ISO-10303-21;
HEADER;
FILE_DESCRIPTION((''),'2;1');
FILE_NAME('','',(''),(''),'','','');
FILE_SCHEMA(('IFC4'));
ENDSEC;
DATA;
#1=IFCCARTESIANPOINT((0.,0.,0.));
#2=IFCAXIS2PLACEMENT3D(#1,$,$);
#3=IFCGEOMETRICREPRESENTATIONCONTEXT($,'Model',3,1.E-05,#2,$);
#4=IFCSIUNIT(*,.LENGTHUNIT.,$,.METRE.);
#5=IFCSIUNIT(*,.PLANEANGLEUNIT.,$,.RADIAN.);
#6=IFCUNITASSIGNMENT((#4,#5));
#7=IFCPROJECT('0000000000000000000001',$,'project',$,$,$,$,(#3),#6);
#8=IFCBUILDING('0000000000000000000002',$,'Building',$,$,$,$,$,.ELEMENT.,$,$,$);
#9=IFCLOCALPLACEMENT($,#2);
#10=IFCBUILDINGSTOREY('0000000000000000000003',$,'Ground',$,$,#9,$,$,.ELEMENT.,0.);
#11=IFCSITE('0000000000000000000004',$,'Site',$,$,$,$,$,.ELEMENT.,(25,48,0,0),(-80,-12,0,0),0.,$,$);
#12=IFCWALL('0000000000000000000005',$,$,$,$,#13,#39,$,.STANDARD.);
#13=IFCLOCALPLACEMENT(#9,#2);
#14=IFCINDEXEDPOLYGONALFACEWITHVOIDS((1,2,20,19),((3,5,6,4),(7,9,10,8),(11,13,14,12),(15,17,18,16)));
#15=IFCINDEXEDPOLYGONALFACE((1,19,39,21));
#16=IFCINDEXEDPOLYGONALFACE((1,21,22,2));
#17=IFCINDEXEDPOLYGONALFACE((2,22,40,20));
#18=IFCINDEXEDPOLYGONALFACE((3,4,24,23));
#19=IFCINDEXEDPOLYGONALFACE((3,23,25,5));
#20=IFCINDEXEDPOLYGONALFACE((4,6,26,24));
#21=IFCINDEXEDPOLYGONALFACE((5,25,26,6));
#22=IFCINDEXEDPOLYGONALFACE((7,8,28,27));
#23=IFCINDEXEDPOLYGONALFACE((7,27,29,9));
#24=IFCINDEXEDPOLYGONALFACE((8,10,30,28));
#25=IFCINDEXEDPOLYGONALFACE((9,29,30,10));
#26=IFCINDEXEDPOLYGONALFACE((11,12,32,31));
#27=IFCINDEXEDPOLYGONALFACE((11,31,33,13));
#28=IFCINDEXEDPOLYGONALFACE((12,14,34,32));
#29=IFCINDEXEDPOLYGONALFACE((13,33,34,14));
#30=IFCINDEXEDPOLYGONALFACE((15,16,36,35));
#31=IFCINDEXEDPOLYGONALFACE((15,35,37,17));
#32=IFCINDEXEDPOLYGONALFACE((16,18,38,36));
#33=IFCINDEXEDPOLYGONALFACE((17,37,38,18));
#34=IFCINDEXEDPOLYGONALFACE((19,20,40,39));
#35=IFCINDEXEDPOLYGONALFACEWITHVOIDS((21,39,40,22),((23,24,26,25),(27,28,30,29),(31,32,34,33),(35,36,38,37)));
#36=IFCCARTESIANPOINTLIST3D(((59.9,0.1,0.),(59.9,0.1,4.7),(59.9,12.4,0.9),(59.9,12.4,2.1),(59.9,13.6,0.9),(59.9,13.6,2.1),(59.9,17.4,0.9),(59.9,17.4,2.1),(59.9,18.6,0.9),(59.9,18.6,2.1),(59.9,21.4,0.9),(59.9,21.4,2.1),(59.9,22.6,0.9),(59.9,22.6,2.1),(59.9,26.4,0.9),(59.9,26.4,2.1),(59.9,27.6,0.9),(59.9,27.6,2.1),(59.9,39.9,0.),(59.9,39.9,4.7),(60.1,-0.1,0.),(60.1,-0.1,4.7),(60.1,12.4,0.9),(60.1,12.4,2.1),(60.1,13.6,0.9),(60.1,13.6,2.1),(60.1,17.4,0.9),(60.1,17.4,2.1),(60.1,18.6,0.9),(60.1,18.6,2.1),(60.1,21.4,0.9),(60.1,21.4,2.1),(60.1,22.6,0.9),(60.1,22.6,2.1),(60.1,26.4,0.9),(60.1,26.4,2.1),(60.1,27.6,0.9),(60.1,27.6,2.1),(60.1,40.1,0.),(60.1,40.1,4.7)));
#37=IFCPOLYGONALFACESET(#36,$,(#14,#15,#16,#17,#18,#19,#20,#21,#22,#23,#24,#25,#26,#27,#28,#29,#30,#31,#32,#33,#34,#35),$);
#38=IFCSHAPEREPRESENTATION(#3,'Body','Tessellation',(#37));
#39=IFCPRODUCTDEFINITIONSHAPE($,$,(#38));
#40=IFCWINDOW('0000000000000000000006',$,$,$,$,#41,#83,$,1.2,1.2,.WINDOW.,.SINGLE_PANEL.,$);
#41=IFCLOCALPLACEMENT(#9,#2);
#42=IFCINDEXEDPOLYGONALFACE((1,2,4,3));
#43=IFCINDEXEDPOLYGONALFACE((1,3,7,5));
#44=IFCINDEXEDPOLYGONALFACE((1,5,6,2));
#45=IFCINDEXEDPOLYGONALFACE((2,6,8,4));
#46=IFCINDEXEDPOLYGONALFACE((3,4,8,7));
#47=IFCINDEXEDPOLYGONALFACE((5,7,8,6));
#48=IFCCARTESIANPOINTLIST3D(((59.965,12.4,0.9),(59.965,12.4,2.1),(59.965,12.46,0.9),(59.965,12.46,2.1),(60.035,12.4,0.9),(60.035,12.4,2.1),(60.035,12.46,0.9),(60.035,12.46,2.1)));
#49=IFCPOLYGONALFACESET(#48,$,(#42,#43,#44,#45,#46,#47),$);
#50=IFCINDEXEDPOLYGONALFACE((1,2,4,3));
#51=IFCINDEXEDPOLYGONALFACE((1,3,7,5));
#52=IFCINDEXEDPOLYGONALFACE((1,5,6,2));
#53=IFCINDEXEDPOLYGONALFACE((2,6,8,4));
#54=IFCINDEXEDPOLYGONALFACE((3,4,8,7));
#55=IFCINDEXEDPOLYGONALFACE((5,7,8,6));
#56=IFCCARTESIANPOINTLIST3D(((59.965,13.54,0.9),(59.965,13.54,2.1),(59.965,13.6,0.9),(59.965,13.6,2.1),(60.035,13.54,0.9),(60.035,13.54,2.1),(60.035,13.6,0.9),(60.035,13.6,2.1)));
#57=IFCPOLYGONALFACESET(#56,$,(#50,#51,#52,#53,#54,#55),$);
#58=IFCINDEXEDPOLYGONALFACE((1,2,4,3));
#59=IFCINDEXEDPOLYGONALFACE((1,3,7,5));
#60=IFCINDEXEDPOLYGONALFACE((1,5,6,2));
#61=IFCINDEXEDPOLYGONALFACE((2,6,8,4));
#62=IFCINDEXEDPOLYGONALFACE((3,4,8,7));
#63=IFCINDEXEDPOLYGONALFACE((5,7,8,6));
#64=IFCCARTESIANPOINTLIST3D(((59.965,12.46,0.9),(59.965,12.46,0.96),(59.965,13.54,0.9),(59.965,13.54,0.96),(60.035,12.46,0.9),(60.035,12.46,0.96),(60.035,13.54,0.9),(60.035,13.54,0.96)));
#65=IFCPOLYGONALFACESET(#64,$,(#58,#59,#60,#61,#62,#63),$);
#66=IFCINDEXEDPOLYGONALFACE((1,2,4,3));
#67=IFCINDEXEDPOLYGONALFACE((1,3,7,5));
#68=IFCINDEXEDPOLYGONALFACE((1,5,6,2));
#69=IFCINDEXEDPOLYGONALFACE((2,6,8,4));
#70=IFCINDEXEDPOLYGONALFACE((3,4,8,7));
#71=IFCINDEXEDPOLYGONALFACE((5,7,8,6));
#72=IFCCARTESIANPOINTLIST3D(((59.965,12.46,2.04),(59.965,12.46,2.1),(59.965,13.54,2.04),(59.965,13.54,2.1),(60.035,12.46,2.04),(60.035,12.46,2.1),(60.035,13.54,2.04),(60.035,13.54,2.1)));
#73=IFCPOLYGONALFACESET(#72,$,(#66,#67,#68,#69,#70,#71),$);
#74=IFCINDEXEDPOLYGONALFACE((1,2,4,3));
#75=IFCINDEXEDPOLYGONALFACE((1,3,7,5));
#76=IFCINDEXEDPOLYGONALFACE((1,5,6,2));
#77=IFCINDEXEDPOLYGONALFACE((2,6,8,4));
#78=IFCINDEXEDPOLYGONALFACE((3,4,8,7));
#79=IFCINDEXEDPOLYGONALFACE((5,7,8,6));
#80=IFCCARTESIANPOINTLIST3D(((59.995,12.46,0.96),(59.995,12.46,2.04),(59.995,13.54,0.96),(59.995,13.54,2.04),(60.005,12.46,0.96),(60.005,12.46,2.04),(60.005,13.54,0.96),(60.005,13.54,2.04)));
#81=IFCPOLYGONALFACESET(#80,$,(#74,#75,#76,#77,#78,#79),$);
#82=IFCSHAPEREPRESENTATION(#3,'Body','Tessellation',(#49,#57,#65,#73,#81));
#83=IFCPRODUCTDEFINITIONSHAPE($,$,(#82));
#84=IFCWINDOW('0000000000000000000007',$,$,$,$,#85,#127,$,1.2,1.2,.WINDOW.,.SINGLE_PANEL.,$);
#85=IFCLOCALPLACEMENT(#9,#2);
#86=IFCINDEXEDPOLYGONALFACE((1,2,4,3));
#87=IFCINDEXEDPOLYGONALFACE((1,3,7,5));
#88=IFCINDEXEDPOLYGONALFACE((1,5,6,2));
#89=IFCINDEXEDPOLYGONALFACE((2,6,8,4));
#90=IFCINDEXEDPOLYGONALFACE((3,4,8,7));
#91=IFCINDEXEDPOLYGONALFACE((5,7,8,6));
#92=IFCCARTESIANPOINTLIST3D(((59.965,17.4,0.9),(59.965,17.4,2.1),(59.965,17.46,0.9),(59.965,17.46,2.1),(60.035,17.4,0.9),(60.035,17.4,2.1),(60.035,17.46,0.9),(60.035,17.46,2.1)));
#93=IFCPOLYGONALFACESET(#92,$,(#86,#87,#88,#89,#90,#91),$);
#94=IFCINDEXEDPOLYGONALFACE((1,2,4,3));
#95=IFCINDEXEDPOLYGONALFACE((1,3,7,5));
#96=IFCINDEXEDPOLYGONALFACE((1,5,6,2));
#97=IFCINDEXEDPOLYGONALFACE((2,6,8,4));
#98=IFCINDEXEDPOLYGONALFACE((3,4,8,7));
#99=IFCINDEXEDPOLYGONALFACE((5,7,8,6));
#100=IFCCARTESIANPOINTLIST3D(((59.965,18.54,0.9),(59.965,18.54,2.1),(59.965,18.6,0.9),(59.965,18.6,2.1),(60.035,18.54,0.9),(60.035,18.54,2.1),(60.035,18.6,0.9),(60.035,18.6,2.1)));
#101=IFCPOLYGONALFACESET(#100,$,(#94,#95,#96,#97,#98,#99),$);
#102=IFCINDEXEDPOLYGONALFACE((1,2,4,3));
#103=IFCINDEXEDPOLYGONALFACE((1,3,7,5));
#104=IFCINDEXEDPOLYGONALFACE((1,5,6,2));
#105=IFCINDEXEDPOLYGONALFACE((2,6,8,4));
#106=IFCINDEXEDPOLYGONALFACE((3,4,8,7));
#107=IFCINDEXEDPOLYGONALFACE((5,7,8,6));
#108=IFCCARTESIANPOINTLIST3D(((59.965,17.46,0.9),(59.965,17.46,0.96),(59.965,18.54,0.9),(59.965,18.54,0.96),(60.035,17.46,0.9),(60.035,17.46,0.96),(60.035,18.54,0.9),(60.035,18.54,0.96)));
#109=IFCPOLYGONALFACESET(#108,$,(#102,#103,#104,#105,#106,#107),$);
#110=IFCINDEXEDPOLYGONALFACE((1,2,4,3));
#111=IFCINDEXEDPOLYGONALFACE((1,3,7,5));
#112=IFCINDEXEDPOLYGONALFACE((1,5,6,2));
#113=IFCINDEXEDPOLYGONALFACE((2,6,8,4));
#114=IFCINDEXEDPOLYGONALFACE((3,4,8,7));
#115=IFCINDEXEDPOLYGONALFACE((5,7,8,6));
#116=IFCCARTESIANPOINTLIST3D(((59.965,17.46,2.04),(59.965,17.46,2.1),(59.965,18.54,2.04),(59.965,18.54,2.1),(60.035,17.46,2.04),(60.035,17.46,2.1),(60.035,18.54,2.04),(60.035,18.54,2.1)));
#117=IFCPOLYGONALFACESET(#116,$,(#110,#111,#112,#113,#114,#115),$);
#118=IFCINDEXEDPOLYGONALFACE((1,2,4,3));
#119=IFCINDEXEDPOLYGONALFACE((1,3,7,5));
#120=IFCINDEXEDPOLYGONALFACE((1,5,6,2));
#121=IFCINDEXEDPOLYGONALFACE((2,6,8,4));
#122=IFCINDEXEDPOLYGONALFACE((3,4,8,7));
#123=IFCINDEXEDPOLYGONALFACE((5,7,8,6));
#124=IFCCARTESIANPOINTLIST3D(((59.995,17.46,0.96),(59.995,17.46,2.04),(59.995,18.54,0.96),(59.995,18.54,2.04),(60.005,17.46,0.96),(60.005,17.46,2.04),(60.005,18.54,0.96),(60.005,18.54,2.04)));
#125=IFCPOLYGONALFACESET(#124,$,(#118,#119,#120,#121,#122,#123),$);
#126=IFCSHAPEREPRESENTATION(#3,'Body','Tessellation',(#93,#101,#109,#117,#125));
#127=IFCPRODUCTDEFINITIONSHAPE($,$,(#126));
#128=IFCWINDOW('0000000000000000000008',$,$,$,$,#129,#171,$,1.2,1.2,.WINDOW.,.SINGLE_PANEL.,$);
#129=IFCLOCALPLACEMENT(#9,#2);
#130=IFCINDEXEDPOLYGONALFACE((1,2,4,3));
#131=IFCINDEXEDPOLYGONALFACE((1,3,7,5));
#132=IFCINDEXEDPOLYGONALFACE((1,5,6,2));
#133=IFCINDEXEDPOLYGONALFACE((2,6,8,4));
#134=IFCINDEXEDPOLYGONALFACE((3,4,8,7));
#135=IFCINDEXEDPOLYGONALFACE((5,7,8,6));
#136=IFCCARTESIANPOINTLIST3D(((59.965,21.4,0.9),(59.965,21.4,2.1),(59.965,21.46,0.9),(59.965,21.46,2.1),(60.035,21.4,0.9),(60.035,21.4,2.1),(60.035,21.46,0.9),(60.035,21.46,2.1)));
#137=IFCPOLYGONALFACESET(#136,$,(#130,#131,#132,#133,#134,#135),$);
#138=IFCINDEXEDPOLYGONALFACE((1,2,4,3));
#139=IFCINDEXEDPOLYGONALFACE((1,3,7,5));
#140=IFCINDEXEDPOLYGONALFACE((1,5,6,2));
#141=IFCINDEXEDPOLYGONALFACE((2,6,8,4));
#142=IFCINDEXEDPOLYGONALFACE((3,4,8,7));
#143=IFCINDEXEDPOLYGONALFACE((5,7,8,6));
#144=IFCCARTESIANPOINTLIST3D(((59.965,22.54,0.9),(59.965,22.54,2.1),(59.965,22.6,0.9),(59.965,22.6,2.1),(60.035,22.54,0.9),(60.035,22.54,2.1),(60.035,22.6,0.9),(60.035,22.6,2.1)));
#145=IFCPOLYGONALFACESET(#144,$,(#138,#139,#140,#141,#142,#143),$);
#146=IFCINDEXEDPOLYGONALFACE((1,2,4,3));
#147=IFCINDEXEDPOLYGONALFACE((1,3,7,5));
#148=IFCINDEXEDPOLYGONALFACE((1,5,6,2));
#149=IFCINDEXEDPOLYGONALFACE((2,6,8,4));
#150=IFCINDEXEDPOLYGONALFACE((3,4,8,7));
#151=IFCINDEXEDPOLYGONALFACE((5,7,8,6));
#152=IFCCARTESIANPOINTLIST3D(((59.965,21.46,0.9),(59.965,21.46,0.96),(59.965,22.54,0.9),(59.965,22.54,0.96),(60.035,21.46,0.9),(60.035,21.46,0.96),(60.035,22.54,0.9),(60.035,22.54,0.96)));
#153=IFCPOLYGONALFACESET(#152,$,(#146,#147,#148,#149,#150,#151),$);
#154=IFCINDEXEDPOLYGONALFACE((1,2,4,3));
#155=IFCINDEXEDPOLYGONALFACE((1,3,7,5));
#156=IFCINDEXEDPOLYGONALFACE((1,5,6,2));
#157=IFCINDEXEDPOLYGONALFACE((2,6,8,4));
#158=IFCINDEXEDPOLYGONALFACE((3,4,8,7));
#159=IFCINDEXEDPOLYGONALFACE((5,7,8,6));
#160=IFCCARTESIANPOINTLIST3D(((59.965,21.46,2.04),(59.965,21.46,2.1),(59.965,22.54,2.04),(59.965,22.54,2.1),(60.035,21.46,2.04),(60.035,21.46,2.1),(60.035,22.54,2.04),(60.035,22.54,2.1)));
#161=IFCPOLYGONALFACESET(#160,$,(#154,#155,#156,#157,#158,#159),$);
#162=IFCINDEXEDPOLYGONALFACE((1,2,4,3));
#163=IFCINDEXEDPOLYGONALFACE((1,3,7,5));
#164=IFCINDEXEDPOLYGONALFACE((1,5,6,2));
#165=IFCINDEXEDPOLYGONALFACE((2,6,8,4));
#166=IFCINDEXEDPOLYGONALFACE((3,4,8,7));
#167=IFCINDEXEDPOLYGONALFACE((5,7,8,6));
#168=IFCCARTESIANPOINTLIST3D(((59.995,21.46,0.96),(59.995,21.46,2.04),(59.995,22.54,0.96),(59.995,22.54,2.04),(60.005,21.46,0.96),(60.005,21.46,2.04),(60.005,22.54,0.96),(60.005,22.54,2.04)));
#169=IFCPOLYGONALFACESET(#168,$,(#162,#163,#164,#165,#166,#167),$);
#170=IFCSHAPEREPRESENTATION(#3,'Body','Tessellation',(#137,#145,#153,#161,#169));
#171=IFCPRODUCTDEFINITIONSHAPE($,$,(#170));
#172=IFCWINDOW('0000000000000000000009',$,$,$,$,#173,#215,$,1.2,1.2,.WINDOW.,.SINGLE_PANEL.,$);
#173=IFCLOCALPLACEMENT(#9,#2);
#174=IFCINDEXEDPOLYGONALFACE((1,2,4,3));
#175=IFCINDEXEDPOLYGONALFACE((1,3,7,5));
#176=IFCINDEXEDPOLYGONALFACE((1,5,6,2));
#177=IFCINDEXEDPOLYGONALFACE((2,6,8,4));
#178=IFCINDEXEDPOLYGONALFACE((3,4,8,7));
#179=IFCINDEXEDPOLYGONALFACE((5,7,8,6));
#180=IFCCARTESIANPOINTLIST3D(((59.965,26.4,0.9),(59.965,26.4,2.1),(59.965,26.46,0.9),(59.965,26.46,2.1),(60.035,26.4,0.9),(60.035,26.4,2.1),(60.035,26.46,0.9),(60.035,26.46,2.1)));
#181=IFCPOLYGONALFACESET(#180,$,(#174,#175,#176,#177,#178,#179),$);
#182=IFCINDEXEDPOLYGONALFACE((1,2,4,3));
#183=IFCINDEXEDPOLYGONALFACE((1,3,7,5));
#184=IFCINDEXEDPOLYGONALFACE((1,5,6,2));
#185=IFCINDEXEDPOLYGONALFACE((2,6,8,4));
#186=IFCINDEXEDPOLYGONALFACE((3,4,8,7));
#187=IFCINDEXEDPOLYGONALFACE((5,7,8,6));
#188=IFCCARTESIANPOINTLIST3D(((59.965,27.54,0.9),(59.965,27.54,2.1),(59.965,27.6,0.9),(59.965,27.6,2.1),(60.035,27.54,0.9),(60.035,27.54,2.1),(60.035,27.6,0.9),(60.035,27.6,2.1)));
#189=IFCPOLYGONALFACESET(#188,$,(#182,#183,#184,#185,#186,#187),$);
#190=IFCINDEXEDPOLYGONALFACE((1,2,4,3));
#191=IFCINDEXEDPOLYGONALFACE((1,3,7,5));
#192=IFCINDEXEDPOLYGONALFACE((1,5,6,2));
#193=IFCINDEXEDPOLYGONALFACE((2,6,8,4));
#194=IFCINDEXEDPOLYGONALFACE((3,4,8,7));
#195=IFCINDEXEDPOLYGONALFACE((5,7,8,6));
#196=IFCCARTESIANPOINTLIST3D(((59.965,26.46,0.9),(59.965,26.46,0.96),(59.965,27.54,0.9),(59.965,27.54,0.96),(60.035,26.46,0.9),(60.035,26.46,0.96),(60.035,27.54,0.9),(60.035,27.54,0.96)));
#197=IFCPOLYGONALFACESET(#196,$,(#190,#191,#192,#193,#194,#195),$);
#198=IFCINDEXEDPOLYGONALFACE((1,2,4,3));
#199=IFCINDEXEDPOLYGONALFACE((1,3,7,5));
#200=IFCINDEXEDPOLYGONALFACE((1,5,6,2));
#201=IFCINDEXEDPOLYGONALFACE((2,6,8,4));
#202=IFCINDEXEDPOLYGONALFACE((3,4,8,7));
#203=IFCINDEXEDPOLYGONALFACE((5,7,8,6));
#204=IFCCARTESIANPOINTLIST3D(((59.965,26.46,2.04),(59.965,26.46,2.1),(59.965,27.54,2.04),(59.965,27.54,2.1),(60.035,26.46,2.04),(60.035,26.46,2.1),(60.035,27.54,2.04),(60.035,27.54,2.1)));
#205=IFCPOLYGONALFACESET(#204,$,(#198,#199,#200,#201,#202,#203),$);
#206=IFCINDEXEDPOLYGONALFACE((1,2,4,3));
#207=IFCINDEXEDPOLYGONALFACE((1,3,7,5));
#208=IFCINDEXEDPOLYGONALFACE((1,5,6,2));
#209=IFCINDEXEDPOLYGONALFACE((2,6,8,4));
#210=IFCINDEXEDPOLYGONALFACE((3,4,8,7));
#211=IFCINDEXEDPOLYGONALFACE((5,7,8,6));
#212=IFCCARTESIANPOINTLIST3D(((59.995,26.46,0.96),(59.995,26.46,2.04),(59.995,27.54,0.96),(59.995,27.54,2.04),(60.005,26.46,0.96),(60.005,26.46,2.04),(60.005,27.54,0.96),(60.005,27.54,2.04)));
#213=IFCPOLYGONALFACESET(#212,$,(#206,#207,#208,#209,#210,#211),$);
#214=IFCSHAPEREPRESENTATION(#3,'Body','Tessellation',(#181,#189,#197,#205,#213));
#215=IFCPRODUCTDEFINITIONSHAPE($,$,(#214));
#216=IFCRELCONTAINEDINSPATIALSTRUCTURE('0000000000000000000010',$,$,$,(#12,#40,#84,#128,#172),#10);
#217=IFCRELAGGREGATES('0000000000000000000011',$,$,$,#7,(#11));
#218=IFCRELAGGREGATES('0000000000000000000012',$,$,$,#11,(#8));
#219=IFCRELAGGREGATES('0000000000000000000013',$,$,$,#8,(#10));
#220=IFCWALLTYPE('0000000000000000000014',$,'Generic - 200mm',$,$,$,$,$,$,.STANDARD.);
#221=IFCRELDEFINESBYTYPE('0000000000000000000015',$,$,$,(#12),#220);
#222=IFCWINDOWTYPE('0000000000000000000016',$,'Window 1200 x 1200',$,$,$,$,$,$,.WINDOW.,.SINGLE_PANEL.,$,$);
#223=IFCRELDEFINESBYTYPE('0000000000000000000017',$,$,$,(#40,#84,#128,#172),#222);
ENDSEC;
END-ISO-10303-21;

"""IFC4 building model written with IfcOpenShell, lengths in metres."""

from ifc_helpers import new_model, si_unit, frame, frame_2d, origin, origin_with_axes, origin_2d, place, context, project, spatial, polyline, rectangle, outline, extrude, type_object, element, fill, save


model = new_model("IFC4")

# Units and contexts
model_context = context("Model", 3, precision=1e-05, world=origin())
ifc_project = project(units=[si_unit("LENGTHUNIT", "METRE"), si_unit("PLANEANGLEUNIT", "RADIAN")], contexts=[model_context])

# Site, building, storey
site = spatial("IfcSite", under=ifc_project, Name="Site", CompositionType="ELEMENT", RefLatitude=(25, 48, 0, 0), RefLongitude=(-80, -12, 0, 0), RefElevation=0.0)
building = spatial("IfcBuilding", under=site, Name="Building", CompositionType="ELEMENT")
storey_placement = place(None, origin())
storey = spatial("IfcBuildingStorey", under=building, at=storey_placement, Name="Ground", CompositionType="ELEMENT", Elevation=0.0)

# Wall, openings, windows
wall_type_1 = type_object("IfcWallType", Name="Generic - 200mm", PredefinedType="STANDARD")
wall_1_placement = place(None, frame((60.0, 0.0, 0.0), z_axis=(0.0, 0.0, 1.0), x_axis=(0.0, 1.0, 0.0)))
wall_1 = element("IfcWall", 1, at=wall_1_placement, inside=storey, type_object=wall_type_1, PredefinedType="STANDARD", context=model_context, shape_type="SweptSolid", body=[
    extrude(outline(polyline([(-0.1, -0.1), (40.1, -0.1), (39.9, 0.1), (0.1, 0.1), (-0.1, -0.1)])), origin(), (0.0, 0.0, 1.0), 4.7),
])
opening_1_placement = place(wall_1_placement, frame((13.0, 0.0, 0.9), z_axis=(0.0, 0.0, 1.0), x_axis=(1.0, 0.0, 0.0)))
opening_1 = element("IfcOpeningElement", 2, at=opening_1_placement, cuts=wall_1, PredefinedType="OPENING", context=model_context, shape_type="SweptSolid", body=[
    extrude(rectangle(XDim=1.2, YDim=0.202, at=origin_2d()), origin(), (0.0, 0.0, 1.0), 1.2),
])
opening_2_placement = place(wall_1_placement, frame((18.0, 0.0, 0.9), z_axis=(0.0, 0.0, 1.0), x_axis=(1.0, 0.0, 0.0)))
opening_2 = element("IfcOpeningElement", 3, at=opening_2_placement, cuts=wall_1, PredefinedType="OPENING", context=model_context, shape_type="SweptSolid", body=[
    extrude(rectangle(XDim=1.2, YDim=0.202, at=origin_2d()), origin(), (0.0, 0.0, 1.0), 1.2),
])
opening_3_placement = place(wall_1_placement, frame((22.0, 0.0, 0.9), z_axis=(0.0, 0.0, 1.0), x_axis=(1.0, 0.0, 0.0)))
opening_3 = element("IfcOpeningElement", 4, at=opening_3_placement, cuts=wall_1, PredefinedType="OPENING", context=model_context, shape_type="SweptSolid", body=[
    extrude(rectangle(XDim=1.2, YDim=0.202, at=origin_2d()), origin(), (0.0, 0.0, 1.0), 1.2),
])
opening_4_placement = place(wall_1_placement, frame((27.0, 0.0, 0.9), z_axis=(0.0, 0.0, 1.0), x_axis=(1.0, 0.0, 0.0)))
opening_4 = element("IfcOpeningElement", 5, at=opening_4_placement, cuts=wall_1, PredefinedType="OPENING", context=model_context, shape_type="SweptSolid", body=[
    extrude(rectangle(XDim=1.2, YDim=0.202, at=origin_2d()), origin(), (0.0, 0.0, 1.0), 1.2),
])
window_type = type_object("IfcWindowType", Name="Window 1200 x 1200", PartitioningType="SINGLE_PANEL", PredefinedType="WINDOW")
window_1_placement = place(opening_1_placement, origin_with_axes())
window_1 = element("IfcWindow", 6, at=window_1_placement, inside=storey, type_object=window_type, OverallHeight=1.2, OverallWidth=1.2, PartitioningType="SINGLE_PANEL", PredefinedType="WINDOW", context=model_context, shape_type="SweptSolid", body=[
    extrude(rectangle(XDim=0.06, YDim=0.07, at=frame_2d((-0.57, 0.0))), origin(), (0.0, 0.0, 1.0), 1.2),
    extrude(rectangle(XDim=0.06, YDim=0.07, at=frame_2d((0.57, 0.0))), origin(), (0.0, 0.0, 1.0), 1.2),
    extrude(rectangle(XDim=1.08, YDim=0.07, at=origin_2d()), origin(), (0.0, 0.0, 1.0), 0.06),
    extrude(rectangle(XDim=1.08, YDim=0.07, at=origin_2d()), frame((0.0, 0.0, 1.14)), (0.0, 0.0, 1.0), 0.06),
    extrude(rectangle(XDim=1.08, YDim=0.01, at=origin_2d()), frame((0.0, 0.0, 0.06)), (0.0, 0.0, 1.0), 1.08),
])
fill(opening_1, window_1)
window_2_placement = place(opening_2_placement, origin_with_axes())
window_2 = element("IfcWindow", 7, at=window_2_placement, inside=storey, type_object=window_type, OverallHeight=1.2, OverallWidth=1.2, PartitioningType="SINGLE_PANEL", PredefinedType="WINDOW", context=model_context, shape_type="SweptSolid", body=[
    extrude(rectangle(XDim=0.06, YDim=0.07, at=frame_2d((-0.57, 0.0))), origin(), (0.0, 0.0, 1.0), 1.2),
    extrude(rectangle(XDim=0.06, YDim=0.07, at=frame_2d((0.57, 0.0))), origin(), (0.0, 0.0, 1.0), 1.2),
    extrude(rectangle(XDim=1.08, YDim=0.07, at=origin_2d()), origin(), (0.0, 0.0, 1.0), 0.06),
    extrude(rectangle(XDim=1.08, YDim=0.07, at=origin_2d()), frame((0.0, 0.0, 1.14)), (0.0, 0.0, 1.0), 0.06),
    extrude(rectangle(XDim=1.08, YDim=0.01, at=origin_2d()), frame((0.0, 0.0, 0.06)), (0.0, 0.0, 1.0), 1.08),
])
fill(opening_2, window_2)
window_3_placement = place(opening_3_placement, origin_with_axes())
window_3 = element("IfcWindow", 8, at=window_3_placement, inside=storey, type_object=window_type, OverallHeight=1.2, OverallWidth=1.2, PartitioningType="SINGLE_PANEL", PredefinedType="WINDOW", context=model_context, shape_type="SweptSolid", body=[
    extrude(rectangle(XDim=0.06, YDim=0.07, at=frame_2d((-0.57, 0.0))), origin(), (0.0, 0.0, 1.0), 1.2),
    extrude(rectangle(XDim=0.06, YDim=0.07, at=frame_2d((0.57, 0.0))), origin(), (0.0, 0.0, 1.0), 1.2),
    extrude(rectangle(XDim=1.08, YDim=0.07, at=origin_2d()), origin(), (0.0, 0.0, 1.0), 0.06),
    extrude(rectangle(XDim=1.08, YDim=0.07, at=origin_2d()), frame((0.0, 0.0, 1.14)), (0.0, 0.0, 1.0), 0.06),
    extrude(rectangle(XDim=1.08, YDim=0.01, at=origin_2d()), frame((0.0, 0.0, 0.06)), (0.0, 0.0, 1.0), 1.08),
])
fill(opening_3, window_3)
window_4_placement = place(opening_4_placement, origin_with_axes())
window_4 = element("IfcWindow", 9, at=window_4_placement, inside=storey, type_object=window_type, OverallHeight=1.2, OverallWidth=1.2, PartitioningType="SINGLE_PANEL", PredefinedType="WINDOW", context=model_context, shape_type="SweptSolid", body=[
    extrude(rectangle(XDim=0.06, YDim=0.07, at=frame_2d((-0.57, 0.0))), origin(), (0.0, 0.0, 1.0), 1.2),
    extrude(rectangle(XDim=0.06, YDim=0.07, at=frame_2d((0.57, 0.0))), origin(), (0.0, 0.0, 1.0), 1.2),
    extrude(rectangle(XDim=1.08, YDim=0.07, at=origin_2d()), origin(), (0.0, 0.0, 1.0), 0.06),
    extrude(rectangle(XDim=1.08, YDim=0.07, at=origin_2d()), frame((0.0, 0.0, 1.14)), (0.0, 0.0, 1.0), 0.06),
    extrude(rectangle(XDim=1.08, YDim=0.01, at=origin_2d()), frame((0.0, 0.0, 0.06)), (0.0, 0.0, 1.0), 1.08),
])
fill(opening_4, window_4)

save(model, "model.ifc")
